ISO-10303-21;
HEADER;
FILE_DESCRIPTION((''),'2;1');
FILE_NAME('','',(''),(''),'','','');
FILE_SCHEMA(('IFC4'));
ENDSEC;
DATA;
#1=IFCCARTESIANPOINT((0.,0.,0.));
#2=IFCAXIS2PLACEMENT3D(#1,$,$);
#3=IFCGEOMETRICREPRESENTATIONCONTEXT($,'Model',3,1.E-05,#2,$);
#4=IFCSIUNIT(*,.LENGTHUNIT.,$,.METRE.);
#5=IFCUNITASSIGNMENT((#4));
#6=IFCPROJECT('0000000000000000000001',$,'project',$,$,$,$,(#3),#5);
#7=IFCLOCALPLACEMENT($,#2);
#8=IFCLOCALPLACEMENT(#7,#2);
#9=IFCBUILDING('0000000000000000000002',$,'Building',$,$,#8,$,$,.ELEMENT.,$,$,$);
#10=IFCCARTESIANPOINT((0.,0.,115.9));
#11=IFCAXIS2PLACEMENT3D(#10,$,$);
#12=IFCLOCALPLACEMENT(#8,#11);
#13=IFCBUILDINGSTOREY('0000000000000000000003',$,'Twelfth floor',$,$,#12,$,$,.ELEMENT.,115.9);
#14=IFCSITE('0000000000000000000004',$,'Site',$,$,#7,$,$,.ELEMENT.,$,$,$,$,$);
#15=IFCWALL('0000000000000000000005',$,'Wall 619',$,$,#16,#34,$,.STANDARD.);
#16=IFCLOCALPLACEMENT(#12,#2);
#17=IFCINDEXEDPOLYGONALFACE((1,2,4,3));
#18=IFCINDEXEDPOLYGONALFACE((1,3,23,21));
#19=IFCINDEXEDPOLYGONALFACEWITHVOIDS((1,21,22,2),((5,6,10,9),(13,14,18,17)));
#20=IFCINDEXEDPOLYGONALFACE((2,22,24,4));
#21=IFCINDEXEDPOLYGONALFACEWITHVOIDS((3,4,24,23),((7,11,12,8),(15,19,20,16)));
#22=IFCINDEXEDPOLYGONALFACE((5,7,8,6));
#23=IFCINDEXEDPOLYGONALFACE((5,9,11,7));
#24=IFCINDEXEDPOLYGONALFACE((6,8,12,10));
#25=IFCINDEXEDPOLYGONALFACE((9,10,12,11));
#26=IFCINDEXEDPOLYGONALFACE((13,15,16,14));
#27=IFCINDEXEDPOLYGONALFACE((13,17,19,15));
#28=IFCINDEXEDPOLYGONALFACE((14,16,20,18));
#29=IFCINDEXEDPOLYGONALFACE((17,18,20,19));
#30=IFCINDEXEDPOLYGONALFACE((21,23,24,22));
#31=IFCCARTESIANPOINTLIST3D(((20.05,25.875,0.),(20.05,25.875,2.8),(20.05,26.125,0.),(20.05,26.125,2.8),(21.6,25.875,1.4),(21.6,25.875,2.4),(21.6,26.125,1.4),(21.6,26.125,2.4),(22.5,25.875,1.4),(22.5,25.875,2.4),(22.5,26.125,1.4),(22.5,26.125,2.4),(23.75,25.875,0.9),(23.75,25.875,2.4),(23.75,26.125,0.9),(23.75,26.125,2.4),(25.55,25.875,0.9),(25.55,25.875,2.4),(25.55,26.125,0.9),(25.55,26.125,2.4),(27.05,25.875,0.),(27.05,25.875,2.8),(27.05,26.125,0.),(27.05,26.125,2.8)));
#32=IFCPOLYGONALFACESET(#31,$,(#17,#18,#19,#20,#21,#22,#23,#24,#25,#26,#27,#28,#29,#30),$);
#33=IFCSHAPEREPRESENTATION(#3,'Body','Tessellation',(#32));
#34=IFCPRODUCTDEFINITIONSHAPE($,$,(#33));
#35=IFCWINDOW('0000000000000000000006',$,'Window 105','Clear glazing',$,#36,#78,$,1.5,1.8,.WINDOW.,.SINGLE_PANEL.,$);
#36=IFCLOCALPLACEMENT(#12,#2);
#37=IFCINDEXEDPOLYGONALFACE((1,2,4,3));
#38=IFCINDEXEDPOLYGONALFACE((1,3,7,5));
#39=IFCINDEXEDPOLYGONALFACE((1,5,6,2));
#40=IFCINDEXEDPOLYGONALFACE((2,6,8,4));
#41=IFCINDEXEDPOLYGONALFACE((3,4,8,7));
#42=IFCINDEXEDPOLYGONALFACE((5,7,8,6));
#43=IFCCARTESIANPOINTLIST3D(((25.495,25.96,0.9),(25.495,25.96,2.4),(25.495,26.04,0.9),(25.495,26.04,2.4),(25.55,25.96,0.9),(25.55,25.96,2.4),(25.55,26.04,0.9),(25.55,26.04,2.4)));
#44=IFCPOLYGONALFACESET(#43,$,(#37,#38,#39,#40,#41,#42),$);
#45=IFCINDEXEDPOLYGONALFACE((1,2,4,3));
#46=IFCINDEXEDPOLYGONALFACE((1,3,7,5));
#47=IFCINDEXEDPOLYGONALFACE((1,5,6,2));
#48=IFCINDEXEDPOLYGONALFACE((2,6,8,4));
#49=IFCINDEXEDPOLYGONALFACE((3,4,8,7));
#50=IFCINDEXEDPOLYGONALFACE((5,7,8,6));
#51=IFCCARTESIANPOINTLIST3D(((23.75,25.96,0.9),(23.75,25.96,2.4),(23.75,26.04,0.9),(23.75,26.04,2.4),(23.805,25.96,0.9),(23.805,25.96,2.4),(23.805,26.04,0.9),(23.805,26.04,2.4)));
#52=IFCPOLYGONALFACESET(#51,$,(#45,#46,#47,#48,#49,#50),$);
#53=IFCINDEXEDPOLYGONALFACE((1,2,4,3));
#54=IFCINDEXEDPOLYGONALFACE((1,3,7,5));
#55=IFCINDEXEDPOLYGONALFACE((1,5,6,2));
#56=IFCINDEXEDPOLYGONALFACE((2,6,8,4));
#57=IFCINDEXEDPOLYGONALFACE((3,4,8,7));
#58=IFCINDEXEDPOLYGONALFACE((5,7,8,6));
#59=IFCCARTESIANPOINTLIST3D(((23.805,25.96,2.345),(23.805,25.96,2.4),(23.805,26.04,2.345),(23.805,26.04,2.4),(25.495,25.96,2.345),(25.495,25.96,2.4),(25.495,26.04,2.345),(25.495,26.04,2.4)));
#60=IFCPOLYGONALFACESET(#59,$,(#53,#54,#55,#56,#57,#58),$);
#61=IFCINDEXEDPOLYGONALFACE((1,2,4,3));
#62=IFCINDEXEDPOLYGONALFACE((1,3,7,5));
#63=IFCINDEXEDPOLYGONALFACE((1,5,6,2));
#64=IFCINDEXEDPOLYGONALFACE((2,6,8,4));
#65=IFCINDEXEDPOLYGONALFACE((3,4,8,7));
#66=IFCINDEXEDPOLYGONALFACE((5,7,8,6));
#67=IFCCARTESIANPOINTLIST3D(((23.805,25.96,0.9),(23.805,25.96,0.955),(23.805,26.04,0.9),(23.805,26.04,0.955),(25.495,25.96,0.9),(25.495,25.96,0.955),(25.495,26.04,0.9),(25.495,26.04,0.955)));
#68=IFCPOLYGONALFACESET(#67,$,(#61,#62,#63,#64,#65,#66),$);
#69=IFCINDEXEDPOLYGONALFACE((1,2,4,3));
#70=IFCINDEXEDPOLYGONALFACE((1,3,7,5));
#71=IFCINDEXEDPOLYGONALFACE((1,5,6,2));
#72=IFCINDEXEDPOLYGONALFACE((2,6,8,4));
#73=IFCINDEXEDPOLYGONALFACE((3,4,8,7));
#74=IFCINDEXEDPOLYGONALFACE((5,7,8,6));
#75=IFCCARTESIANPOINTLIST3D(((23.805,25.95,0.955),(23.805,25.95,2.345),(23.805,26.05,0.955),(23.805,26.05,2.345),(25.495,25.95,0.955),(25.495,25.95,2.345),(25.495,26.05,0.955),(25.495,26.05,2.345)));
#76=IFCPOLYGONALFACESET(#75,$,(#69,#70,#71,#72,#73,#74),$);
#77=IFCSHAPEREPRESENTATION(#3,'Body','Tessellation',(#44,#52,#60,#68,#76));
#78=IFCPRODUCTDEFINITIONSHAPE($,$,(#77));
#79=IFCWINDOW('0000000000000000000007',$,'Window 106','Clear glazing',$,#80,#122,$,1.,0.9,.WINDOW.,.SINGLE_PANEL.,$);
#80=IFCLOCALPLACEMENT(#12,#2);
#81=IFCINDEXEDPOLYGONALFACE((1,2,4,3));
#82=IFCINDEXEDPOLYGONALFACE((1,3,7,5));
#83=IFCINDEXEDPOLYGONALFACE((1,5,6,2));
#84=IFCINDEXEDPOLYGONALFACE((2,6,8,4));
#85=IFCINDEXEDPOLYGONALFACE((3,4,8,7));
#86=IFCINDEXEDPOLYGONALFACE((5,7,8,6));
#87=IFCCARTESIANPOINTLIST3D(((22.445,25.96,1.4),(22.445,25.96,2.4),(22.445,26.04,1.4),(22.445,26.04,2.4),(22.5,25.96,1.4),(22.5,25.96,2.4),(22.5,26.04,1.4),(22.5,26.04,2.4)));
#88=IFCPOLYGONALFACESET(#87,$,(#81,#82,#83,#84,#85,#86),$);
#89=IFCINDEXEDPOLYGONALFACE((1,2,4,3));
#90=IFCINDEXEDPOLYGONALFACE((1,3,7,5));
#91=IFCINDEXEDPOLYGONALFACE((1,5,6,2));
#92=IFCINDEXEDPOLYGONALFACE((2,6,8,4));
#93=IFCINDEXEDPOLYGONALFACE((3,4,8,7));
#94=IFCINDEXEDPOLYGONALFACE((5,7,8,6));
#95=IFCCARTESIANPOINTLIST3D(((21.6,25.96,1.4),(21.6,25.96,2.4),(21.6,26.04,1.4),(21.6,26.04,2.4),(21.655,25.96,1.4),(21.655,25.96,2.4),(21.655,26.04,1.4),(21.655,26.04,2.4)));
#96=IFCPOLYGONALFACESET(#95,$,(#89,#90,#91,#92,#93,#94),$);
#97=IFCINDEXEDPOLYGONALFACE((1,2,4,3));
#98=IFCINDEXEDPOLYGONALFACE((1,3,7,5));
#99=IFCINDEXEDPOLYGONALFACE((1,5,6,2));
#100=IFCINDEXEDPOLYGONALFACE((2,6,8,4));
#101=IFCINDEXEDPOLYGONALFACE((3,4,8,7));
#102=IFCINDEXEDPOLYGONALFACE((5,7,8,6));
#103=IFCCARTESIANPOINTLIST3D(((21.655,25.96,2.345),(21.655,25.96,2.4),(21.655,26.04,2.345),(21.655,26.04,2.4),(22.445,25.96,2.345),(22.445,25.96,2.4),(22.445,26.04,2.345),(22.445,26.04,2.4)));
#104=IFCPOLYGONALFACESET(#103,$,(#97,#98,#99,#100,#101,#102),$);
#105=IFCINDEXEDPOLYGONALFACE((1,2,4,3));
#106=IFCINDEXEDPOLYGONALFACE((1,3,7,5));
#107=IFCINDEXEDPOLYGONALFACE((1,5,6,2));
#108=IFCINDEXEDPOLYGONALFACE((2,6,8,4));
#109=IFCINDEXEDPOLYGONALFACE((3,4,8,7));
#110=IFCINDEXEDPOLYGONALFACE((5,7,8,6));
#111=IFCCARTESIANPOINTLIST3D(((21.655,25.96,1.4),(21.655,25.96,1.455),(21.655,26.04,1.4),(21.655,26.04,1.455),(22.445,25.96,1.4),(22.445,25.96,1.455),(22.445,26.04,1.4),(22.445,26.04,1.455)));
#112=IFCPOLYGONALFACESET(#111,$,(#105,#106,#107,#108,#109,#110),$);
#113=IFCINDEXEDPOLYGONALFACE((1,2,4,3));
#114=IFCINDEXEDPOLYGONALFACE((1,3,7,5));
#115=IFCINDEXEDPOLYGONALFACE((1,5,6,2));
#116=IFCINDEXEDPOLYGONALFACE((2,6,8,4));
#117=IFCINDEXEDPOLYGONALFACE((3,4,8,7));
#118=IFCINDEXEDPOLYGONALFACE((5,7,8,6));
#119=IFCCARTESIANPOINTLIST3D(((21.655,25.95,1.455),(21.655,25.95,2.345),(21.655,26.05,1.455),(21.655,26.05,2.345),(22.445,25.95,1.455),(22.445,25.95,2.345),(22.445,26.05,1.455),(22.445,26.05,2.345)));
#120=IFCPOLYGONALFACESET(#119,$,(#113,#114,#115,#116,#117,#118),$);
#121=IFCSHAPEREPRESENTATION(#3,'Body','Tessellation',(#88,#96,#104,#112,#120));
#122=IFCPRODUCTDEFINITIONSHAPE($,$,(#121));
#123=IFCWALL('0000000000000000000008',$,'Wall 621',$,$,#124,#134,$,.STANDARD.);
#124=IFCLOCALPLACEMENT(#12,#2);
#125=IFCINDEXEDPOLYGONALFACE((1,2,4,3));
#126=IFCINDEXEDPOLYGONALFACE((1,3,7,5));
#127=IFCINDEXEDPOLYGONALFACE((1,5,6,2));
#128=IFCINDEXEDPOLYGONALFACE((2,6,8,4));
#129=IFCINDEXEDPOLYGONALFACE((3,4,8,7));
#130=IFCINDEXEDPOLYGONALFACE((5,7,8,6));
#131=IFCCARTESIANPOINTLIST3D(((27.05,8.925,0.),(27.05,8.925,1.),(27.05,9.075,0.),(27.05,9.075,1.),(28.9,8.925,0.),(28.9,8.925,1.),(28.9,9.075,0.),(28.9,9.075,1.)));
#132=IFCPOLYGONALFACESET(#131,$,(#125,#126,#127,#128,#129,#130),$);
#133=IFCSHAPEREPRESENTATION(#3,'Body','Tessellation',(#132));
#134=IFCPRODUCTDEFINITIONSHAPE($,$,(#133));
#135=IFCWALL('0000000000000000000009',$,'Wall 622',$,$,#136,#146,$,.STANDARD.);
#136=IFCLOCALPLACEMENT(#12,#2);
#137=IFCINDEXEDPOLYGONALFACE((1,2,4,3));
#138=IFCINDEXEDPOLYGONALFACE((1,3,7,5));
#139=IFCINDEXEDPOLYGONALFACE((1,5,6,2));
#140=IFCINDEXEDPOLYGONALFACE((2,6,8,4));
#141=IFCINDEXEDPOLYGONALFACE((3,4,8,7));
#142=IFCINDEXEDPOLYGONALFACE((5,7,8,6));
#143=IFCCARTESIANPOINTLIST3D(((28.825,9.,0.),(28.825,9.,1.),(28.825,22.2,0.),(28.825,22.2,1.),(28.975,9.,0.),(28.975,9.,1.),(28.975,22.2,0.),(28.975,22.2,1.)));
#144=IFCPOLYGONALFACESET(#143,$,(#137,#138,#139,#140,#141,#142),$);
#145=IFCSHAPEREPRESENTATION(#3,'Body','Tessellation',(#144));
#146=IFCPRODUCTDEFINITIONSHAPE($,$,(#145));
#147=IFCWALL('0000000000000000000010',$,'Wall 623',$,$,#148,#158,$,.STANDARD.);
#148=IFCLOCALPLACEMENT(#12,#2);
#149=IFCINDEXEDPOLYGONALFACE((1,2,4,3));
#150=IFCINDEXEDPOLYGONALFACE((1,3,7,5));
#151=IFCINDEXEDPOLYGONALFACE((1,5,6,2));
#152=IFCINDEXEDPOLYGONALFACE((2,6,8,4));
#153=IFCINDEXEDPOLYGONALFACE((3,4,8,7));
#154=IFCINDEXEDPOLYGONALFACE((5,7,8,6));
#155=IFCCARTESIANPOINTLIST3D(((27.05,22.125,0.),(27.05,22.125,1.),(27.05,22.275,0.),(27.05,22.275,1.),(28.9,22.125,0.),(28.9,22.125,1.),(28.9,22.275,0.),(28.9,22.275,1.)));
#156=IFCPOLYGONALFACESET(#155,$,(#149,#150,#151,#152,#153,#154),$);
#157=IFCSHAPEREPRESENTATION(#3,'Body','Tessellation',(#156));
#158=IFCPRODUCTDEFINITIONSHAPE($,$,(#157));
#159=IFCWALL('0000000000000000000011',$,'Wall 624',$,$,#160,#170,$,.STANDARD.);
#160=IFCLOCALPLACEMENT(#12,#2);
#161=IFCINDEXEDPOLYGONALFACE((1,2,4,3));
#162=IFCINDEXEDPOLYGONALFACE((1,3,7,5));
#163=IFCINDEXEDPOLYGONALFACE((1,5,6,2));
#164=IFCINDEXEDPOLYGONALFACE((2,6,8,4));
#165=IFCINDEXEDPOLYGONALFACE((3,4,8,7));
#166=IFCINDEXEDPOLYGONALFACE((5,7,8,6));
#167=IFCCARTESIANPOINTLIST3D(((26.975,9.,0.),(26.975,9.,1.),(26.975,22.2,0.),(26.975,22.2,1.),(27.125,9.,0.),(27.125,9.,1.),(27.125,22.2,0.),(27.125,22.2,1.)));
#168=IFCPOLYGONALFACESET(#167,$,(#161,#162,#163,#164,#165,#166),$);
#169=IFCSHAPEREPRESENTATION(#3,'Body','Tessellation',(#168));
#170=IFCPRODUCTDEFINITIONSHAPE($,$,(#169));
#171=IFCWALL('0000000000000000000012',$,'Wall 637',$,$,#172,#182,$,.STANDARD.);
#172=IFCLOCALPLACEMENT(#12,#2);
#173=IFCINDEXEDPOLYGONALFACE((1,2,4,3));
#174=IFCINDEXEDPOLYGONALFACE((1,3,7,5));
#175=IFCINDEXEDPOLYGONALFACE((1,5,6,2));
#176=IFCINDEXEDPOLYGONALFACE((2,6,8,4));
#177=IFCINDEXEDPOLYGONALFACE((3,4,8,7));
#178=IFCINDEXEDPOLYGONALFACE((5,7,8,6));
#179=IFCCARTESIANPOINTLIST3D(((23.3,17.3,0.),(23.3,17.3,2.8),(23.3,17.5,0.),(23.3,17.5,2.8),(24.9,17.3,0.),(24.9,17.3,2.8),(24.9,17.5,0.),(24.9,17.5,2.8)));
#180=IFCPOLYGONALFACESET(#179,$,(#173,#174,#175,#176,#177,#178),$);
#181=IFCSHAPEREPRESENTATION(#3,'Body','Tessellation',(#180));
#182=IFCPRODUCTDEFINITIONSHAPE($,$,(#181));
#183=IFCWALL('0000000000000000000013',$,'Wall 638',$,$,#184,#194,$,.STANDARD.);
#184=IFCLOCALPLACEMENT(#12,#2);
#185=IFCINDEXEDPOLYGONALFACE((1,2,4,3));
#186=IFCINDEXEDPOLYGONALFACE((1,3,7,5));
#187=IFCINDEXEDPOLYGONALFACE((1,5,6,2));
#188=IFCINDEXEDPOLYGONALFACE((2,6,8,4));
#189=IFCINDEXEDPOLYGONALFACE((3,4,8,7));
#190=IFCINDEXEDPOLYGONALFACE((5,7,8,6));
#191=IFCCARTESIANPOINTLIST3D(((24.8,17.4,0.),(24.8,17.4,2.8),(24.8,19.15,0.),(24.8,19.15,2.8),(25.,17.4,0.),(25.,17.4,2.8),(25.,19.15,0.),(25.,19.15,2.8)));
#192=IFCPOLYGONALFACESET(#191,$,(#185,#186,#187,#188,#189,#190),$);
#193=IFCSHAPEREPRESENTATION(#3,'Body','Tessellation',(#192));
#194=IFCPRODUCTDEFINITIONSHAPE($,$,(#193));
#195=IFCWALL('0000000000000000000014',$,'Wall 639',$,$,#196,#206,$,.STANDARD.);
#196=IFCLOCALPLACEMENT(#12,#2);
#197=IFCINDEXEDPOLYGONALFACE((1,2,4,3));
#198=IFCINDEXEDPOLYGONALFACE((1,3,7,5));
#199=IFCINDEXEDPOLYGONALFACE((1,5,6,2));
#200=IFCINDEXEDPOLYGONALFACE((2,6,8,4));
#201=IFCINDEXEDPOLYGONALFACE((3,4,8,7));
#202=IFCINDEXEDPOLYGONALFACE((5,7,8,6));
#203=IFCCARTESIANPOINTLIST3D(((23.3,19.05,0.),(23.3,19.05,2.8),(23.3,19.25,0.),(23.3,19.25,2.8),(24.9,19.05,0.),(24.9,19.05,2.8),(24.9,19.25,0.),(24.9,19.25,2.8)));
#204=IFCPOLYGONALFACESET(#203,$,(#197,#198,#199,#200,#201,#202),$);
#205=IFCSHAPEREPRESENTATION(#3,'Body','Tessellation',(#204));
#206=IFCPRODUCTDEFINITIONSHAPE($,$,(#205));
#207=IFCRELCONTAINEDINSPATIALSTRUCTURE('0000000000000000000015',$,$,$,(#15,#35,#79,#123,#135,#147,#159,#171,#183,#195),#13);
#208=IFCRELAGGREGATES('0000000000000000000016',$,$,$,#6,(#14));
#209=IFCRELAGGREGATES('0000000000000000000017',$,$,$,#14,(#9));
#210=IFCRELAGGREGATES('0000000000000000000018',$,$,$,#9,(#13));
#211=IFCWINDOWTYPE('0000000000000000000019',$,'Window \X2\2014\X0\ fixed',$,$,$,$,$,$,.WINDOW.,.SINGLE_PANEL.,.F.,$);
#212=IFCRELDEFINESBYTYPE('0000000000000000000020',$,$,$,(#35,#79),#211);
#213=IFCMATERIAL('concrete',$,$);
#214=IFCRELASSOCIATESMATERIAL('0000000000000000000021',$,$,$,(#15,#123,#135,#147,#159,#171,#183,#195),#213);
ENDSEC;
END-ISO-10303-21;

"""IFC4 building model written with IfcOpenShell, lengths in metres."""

from ifc_helpers import new_model, si_unit, frame, frame_2d, origin, place, context, project, spatial, rectangle, extrude, material, type_object, element, fill, save


model = new_model("IFC4")

# Units and contexts
model_context = context("Model", 3, precision=1e-05, world=origin())
ifc_project = project(units=[si_unit("LENGTHUNIT", "METRE")], contexts=[model_context])

# Site, building, storey
site_placement = place(None, origin())
site = spatial("IfcSite", under=ifc_project, at=site_placement, Name="Site", CompositionType="ELEMENT")
building_placement = place(site_placement, origin())
building = spatial("IfcBuilding", under=site, at=building_placement, Name="Building", CompositionType="ELEMENT")
storey_placement = place(building_placement, frame((0.0, 0.0, 115.9)))
storey = spatial("IfcBuildingStorey", under=building, at=storey_placement, Name="Twelfth floor", CompositionType="ELEMENT", Elevation=115.9)

# Shared definitions
ifc_material = material(Name="concrete")

# Shared definitions
window_type = type_object("IfcWindowType", Name="Window — fixed", ParameterTakesPrecedence=False, PartitioningType="SINGLE_PANEL", PredefinedType="WINDOW")

# Wall, openings, windows
wall_1_placement = place(storey_placement, frame((27.05, 26.0, 0.0), z_axis=(0.0, 0.0, 1.0), x_axis=(-1.0, 0.0, 0.0)))
wall_1 = element("IfcWall", 1, at=wall_1_placement, inside=storey, material=ifc_material, Name="Wall 619", PredefinedType="STANDARD", context=model_context, shape_type="SweptSolid", body=[
    extrude(rectangle(XDim=7.0, YDim=0.25, at=frame_2d((3.5, 0.0))), origin(), (0.0, 0.0, 1.0), 2.8),
])
opening_1_placement = place(storey_placement, frame((25.55, 26.0, 0.9), z_axis=(0.0, 0.0, 1.0), x_axis=(-1.0, 0.0, 0.0)))
opening_1 = element("IfcOpeningElement", 2, at=opening_1_placement, cuts=wall_1, PredefinedType="OPENING", context=model_context, shape_type="SweptSolid", body=[
    extrude(rectangle(XDim=1.8, YDim=0.31, at=frame_2d((0.9, 0.0))), origin(), (0.0, 0.0, 1.0), 1.5),
])
opening_2_placement = place(storey_placement, frame((22.5, 26.0, 1.4), z_axis=(0.0, 0.0, 1.0), x_axis=(-1.0, 0.0, 0.0)))
opening_2 = element("IfcOpeningElement", 3, at=opening_2_placement, cuts=wall_1, PredefinedType="OPENING", context=model_context, shape_type="SweptSolid", body=[
    extrude(rectangle(XDim=0.9, YDim=0.31, at=frame_2d((0.45, 0.0))), origin(), (0.0, 0.0, 1.0), 1.0),
])
window_1_placement = place(storey_placement, frame((25.55, 26.0, 0.9), z_axis=(0.0, 0.0, 1.0), x_axis=(-1.0, 0.0, 0.0)))
window_1 = element("IfcWindow", 4, at=window_1_placement, inside=storey, type_object=window_type, Name="Window 105", Description="Clear glazing", OverallHeight=1.5, OverallWidth=1.8, PartitioningType="SINGLE_PANEL", PredefinedType="WINDOW", context=model_context, shape_type="SweptSolid", body=[
    extrude(rectangle(XDim=0.055, YDim=0.08, at=frame_2d((0.0275, 0.0))), origin(), (0.0, 0.0, 1.0), 1.5),
    extrude(rectangle(XDim=0.055, YDim=0.08, at=frame_2d((1.7725, 0.0))), origin(), (0.0, 0.0, 1.0), 1.5),
    extrude(rectangle(XDim=1.69, YDim=0.08, at=frame_2d((0.9, 0.0))), frame((0.0, 0.0, 1.445)), (0.0, 0.0, 1.0), 0.055),
    extrude(rectangle(XDim=1.69, YDim=0.08, at=frame_2d((0.9, 0.0))), origin(), (0.0, 0.0, 1.0), 0.055),
    extrude(rectangle(XDim=1.69, YDim=0.1, at=frame_2d((0.9, 0.0))), frame((0.0, 0.0, 0.055)), (0.0, 0.0, 1.0), 1.39),
])
fill(opening_1, window_1)
window_2_placement = place(storey_placement, frame((22.5, 26.0, 1.4), z_axis=(0.0, 0.0, 1.0), x_axis=(-1.0, 0.0, 0.0)))
window_2 = element("IfcWindow", 5, at=window_2_placement, inside=storey, type_object=window_type, Name="Window 106", Description="Clear glazing", OverallHeight=1.0, OverallWidth=0.9, PartitioningType="SINGLE_PANEL", PredefinedType="WINDOW", context=model_context, shape_type="SweptSolid", body=[
    extrude(rectangle(XDim=0.055, YDim=0.08, at=frame_2d((0.0275, 0.0))), origin(), (0.0, 0.0, 1.0), 1.0),
    extrude(rectangle(XDim=0.055, YDim=0.08, at=frame_2d((0.8725, 0.0))), origin(), (0.0, 0.0, 1.0), 1.0),
    extrude(rectangle(XDim=0.79, YDim=0.08, at=frame_2d((0.45, 0.0))), frame((0.0, 0.0, 0.945)), (0.0, 0.0, 1.0), 0.055),
    extrude(rectangle(XDim=0.79, YDim=0.08, at=frame_2d((0.45, 0.0))), origin(), (0.0, 0.0, 1.0), 0.055),
    extrude(rectangle(XDim=0.79, YDim=0.1, at=frame_2d((0.45, 0.0))), frame((0.0, 0.0, 0.055)), (0.0, 0.0, 1.0), 0.89),
])
fill(opening_2, window_2)

# Walls
wall_2_placement = place(storey_placement, frame((27.05, 9.0, 0.0), z_axis=(0.0, 0.0, 1.0), x_axis=(1.0, 0.0, 0.0)))
element("IfcWall", 6, at=wall_2_placement, inside=storey, material=ifc_material, Name="Wall 621", PredefinedType="STANDARD", context=model_context, shape_type="SweptSolid", body=[
    extrude(rectangle(XDim=1.85, YDim=0.15, at=frame_2d((0.925, 0.0))), origin(), (0.0, 0.0, 1.0), 1.0),
])
wall_3_placement = place(storey_placement, frame((28.9, 9.0, 0.0), z_axis=(0.0, 0.0, 1.0), x_axis=(0.0, 1.0, 0.0)))
element("IfcWall", 7, at=wall_3_placement, inside=storey, material=ifc_material, Name="Wall 622", PredefinedType="STANDARD", context=model_context, shape_type="SweptSolid", body=[
    extrude(rectangle(XDim=13.2, YDim=0.15, at=frame_2d((6.6, 0.0))), origin(), (0.0, 0.0, 1.0), 1.0),
])
wall_4_placement = place(storey_placement, frame((28.9, 22.2, 0.0), z_axis=(0.0, 0.0, 1.0), x_axis=(-1.0, 0.0, 0.0)))
element("IfcWall", 8, at=wall_4_placement, inside=storey, material=ifc_material, Name="Wall 623", PredefinedType="STANDARD", context=model_context, shape_type="SweptSolid", body=[
    extrude(rectangle(XDim=1.85, YDim=0.15, at=frame_2d((0.925, 0.0))), origin(), (0.0, 0.0, 1.0), 1.0),
])
wall_5_placement = place(storey_placement, frame((27.05, 22.2, 0.0), z_axis=(0.0, 0.0, 1.0), x_axis=(0.0, -1.0, 0.0)))
element("IfcWall", 9, at=wall_5_placement, inside=storey, material=ifc_material, Name="Wall 624", PredefinedType="STANDARD", context=model_context, shape_type="SweptSolid", body=[
    extrude(rectangle(XDim=13.2, YDim=0.15, at=frame_2d((6.6, 0.0))), origin(), (0.0, 0.0, 1.0), 1.0),
])
wall_6_placement = place(storey_placement, frame((23.3, 17.4, 0.0), z_axis=(0.0, 0.0, 1.0), x_axis=(1.0, 0.0, 0.0)))
element("IfcWall", 10, at=wall_6_placement, inside=storey, material=ifc_material, Name="Wall 637", PredefinedType="STANDARD", context=model_context, shape_type="SweptSolid", body=[
    extrude(rectangle(XDim=1.6, YDim=0.2, at=frame_2d((0.8, 0.0))), origin(), (0.0, 0.0, 1.0), 2.8),
])
wall_7_placement = place(storey_placement, frame((24.9, 17.4, 0.0), z_axis=(0.0, 0.0, 1.0), x_axis=(0.0, 1.0, 0.0)))
element("IfcWall", 11, at=wall_7_placement, inside=storey, material=ifc_material, Name="Wall 638", PredefinedType="STANDARD", context=model_context, shape_type="SweptSolid", body=[
    extrude(rectangle(XDim=1.75, YDim=0.2, at=frame_2d((0.875, 0.0))), origin(), (0.0, 0.0, 1.0), 2.8),
])
wall_8_placement = place(storey_placement, frame((24.9, 19.15, 0.0), z_axis=(0.0, 0.0, 1.0), x_axis=(-1.0, 0.0, 0.0)))
element("IfcWall", 12, at=wall_8_placement, inside=storey, material=ifc_material, Name="Wall 639", PredefinedType="STANDARD", context=model_context, shape_type="SweptSolid", body=[
    extrude(rectangle(XDim=1.6, YDim=0.2, at=frame_2d((0.8, 0.0))), origin(), (0.0, 0.0, 1.0), 2.8),
])

save(model, "model.ifc")
